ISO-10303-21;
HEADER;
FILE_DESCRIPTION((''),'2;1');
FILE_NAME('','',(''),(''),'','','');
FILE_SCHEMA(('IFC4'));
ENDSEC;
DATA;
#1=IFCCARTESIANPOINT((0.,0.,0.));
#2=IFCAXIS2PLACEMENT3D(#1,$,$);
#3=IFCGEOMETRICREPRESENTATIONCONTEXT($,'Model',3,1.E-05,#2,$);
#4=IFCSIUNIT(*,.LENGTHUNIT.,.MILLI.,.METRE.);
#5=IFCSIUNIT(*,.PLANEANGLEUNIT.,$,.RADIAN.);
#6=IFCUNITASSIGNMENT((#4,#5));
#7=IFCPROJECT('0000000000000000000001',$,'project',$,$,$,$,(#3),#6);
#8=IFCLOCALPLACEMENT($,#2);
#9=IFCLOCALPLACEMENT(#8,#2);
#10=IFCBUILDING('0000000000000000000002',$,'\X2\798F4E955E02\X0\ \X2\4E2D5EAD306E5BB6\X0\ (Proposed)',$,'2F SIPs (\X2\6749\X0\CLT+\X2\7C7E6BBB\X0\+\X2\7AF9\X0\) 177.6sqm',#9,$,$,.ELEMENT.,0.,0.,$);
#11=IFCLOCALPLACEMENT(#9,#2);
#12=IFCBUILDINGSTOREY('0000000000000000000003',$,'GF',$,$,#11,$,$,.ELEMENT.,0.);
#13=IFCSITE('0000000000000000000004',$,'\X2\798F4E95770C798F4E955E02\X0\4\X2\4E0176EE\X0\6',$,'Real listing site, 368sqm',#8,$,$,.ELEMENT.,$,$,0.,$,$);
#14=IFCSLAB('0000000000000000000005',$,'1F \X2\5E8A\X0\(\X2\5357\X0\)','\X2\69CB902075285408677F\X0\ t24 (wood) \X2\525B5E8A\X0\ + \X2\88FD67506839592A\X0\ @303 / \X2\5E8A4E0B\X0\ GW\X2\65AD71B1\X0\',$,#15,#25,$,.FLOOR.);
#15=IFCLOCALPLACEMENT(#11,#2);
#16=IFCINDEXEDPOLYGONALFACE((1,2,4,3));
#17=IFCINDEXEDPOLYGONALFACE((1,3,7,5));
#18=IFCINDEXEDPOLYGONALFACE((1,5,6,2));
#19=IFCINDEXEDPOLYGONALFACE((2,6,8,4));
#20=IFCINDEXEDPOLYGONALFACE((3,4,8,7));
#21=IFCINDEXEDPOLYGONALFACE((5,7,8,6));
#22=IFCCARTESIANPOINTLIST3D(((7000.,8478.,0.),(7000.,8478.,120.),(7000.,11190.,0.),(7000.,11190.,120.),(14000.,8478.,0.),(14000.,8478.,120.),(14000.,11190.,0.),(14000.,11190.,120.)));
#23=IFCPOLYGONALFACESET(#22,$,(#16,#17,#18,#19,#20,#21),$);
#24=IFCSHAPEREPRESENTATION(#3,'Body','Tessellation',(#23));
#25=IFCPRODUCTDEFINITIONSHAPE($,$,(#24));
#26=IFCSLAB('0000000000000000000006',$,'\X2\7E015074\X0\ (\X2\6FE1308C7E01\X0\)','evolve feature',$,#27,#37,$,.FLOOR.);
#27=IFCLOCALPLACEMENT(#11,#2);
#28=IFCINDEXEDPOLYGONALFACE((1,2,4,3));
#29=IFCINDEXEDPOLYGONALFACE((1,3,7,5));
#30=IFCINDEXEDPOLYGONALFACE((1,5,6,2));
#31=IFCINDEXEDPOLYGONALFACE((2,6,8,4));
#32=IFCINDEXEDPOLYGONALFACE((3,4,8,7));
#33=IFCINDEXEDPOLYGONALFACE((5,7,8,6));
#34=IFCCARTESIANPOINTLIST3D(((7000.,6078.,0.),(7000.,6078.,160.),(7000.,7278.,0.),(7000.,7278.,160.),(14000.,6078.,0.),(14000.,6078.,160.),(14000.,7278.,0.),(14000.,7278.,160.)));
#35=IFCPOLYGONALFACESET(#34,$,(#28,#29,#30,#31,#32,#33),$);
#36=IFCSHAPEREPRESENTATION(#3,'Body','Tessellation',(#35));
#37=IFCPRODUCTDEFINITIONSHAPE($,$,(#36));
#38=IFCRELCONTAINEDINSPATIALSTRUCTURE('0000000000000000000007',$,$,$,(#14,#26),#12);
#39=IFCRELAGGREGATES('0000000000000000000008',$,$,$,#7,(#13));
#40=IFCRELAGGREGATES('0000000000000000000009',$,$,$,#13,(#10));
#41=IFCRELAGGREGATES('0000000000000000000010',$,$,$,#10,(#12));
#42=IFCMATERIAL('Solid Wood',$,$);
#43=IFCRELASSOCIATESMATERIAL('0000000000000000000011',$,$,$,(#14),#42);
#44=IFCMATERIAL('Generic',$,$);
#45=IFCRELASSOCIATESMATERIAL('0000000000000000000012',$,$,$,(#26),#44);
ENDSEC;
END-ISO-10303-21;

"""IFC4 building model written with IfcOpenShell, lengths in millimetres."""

from ifc_helpers import new_model, si_unit, frame, frame_2d, origin, place, context, project, spatial, rectangle, extrude, material, element, save


model = new_model("IFC4")

# Units and contexts
model_context = context("Model", 3, precision=1e-05, world=origin())
ifc_project = project(units=[si_unit("LENGTHUNIT", "METRE", prefix="MILLI"), si_unit("PLANEANGLEUNIT", "RADIAN")], contexts=[model_context])

# Site, building, storey
site_placement = place(None, origin())
site = spatial("IfcSite", under=ifc_project, at=site_placement, Name="福井県福井市4丁目6", ObjectType="Real listing site, 368sqm", CompositionType="ELEMENT", RefElevation=0.0)
building_placement = place(site_placement, origin())
building = spatial("IfcBuilding", under=site, at=building_placement, Name="福井市 中庭の家 (Proposed)", ObjectType="2F SIPs (杉CLT+籾殻+竹) 177.6sqm", CompositionType="ELEMENT", ElevationOfRefHeight=0.0, ElevationOfTerrain=0.0)
storey_placement = place(building_placement, origin())
storey = spatial("IfcBuildingStorey", under=building, at=storey_placement, Name="GF", CompositionType="ELEMENT", Elevation=0.0)

# Slabs
ifc_material_1 = material(Name="Solid Wood")
slab_1_placement = place(storey_placement, frame((3500.0, 4239.0, 0.0)))
element("IfcSlab", 1, at=slab_1_placement, inside=storey, material=ifc_material_1, Name="1F 床(南)", Description="構造用合板 t24 (wood) 剛床 + 製材根太 @303 / 床下 GW断熱", PredefinedType="FLOOR", context=model_context, shape_type="SweptSolid", body=[
    extrude(rectangle(XDim=7000.0, YDim=2712.0, at=frame_2d((3500.0, 1356.0))), frame((3500.0, 4239.0, 0.0)), (0.0, 0.0, 1.0), 120.0),
])
ifc_material_2 = material(Name="Generic")
slab_2_placement = place(storey_placement, frame((3500.0, 3039.0, 0.0)))
element("IfcSlab", 2, at=slab_2_placement, inside=storey, material=ifc_material_2, Name="縁側 (濡れ縁)", Description="evolve feature", PredefinedType="FLOOR", context=model_context, shape_type="SweptSolid", body=[
    extrude(rectangle(XDim=7000.0, YDim=1200.0, at=frame_2d((3500.0, 600.0))), frame((3500.0, 3039.0, 0.0)), (0.0, 0.0, 1.0), 160.0),
])

save(model, "model.ifc")
